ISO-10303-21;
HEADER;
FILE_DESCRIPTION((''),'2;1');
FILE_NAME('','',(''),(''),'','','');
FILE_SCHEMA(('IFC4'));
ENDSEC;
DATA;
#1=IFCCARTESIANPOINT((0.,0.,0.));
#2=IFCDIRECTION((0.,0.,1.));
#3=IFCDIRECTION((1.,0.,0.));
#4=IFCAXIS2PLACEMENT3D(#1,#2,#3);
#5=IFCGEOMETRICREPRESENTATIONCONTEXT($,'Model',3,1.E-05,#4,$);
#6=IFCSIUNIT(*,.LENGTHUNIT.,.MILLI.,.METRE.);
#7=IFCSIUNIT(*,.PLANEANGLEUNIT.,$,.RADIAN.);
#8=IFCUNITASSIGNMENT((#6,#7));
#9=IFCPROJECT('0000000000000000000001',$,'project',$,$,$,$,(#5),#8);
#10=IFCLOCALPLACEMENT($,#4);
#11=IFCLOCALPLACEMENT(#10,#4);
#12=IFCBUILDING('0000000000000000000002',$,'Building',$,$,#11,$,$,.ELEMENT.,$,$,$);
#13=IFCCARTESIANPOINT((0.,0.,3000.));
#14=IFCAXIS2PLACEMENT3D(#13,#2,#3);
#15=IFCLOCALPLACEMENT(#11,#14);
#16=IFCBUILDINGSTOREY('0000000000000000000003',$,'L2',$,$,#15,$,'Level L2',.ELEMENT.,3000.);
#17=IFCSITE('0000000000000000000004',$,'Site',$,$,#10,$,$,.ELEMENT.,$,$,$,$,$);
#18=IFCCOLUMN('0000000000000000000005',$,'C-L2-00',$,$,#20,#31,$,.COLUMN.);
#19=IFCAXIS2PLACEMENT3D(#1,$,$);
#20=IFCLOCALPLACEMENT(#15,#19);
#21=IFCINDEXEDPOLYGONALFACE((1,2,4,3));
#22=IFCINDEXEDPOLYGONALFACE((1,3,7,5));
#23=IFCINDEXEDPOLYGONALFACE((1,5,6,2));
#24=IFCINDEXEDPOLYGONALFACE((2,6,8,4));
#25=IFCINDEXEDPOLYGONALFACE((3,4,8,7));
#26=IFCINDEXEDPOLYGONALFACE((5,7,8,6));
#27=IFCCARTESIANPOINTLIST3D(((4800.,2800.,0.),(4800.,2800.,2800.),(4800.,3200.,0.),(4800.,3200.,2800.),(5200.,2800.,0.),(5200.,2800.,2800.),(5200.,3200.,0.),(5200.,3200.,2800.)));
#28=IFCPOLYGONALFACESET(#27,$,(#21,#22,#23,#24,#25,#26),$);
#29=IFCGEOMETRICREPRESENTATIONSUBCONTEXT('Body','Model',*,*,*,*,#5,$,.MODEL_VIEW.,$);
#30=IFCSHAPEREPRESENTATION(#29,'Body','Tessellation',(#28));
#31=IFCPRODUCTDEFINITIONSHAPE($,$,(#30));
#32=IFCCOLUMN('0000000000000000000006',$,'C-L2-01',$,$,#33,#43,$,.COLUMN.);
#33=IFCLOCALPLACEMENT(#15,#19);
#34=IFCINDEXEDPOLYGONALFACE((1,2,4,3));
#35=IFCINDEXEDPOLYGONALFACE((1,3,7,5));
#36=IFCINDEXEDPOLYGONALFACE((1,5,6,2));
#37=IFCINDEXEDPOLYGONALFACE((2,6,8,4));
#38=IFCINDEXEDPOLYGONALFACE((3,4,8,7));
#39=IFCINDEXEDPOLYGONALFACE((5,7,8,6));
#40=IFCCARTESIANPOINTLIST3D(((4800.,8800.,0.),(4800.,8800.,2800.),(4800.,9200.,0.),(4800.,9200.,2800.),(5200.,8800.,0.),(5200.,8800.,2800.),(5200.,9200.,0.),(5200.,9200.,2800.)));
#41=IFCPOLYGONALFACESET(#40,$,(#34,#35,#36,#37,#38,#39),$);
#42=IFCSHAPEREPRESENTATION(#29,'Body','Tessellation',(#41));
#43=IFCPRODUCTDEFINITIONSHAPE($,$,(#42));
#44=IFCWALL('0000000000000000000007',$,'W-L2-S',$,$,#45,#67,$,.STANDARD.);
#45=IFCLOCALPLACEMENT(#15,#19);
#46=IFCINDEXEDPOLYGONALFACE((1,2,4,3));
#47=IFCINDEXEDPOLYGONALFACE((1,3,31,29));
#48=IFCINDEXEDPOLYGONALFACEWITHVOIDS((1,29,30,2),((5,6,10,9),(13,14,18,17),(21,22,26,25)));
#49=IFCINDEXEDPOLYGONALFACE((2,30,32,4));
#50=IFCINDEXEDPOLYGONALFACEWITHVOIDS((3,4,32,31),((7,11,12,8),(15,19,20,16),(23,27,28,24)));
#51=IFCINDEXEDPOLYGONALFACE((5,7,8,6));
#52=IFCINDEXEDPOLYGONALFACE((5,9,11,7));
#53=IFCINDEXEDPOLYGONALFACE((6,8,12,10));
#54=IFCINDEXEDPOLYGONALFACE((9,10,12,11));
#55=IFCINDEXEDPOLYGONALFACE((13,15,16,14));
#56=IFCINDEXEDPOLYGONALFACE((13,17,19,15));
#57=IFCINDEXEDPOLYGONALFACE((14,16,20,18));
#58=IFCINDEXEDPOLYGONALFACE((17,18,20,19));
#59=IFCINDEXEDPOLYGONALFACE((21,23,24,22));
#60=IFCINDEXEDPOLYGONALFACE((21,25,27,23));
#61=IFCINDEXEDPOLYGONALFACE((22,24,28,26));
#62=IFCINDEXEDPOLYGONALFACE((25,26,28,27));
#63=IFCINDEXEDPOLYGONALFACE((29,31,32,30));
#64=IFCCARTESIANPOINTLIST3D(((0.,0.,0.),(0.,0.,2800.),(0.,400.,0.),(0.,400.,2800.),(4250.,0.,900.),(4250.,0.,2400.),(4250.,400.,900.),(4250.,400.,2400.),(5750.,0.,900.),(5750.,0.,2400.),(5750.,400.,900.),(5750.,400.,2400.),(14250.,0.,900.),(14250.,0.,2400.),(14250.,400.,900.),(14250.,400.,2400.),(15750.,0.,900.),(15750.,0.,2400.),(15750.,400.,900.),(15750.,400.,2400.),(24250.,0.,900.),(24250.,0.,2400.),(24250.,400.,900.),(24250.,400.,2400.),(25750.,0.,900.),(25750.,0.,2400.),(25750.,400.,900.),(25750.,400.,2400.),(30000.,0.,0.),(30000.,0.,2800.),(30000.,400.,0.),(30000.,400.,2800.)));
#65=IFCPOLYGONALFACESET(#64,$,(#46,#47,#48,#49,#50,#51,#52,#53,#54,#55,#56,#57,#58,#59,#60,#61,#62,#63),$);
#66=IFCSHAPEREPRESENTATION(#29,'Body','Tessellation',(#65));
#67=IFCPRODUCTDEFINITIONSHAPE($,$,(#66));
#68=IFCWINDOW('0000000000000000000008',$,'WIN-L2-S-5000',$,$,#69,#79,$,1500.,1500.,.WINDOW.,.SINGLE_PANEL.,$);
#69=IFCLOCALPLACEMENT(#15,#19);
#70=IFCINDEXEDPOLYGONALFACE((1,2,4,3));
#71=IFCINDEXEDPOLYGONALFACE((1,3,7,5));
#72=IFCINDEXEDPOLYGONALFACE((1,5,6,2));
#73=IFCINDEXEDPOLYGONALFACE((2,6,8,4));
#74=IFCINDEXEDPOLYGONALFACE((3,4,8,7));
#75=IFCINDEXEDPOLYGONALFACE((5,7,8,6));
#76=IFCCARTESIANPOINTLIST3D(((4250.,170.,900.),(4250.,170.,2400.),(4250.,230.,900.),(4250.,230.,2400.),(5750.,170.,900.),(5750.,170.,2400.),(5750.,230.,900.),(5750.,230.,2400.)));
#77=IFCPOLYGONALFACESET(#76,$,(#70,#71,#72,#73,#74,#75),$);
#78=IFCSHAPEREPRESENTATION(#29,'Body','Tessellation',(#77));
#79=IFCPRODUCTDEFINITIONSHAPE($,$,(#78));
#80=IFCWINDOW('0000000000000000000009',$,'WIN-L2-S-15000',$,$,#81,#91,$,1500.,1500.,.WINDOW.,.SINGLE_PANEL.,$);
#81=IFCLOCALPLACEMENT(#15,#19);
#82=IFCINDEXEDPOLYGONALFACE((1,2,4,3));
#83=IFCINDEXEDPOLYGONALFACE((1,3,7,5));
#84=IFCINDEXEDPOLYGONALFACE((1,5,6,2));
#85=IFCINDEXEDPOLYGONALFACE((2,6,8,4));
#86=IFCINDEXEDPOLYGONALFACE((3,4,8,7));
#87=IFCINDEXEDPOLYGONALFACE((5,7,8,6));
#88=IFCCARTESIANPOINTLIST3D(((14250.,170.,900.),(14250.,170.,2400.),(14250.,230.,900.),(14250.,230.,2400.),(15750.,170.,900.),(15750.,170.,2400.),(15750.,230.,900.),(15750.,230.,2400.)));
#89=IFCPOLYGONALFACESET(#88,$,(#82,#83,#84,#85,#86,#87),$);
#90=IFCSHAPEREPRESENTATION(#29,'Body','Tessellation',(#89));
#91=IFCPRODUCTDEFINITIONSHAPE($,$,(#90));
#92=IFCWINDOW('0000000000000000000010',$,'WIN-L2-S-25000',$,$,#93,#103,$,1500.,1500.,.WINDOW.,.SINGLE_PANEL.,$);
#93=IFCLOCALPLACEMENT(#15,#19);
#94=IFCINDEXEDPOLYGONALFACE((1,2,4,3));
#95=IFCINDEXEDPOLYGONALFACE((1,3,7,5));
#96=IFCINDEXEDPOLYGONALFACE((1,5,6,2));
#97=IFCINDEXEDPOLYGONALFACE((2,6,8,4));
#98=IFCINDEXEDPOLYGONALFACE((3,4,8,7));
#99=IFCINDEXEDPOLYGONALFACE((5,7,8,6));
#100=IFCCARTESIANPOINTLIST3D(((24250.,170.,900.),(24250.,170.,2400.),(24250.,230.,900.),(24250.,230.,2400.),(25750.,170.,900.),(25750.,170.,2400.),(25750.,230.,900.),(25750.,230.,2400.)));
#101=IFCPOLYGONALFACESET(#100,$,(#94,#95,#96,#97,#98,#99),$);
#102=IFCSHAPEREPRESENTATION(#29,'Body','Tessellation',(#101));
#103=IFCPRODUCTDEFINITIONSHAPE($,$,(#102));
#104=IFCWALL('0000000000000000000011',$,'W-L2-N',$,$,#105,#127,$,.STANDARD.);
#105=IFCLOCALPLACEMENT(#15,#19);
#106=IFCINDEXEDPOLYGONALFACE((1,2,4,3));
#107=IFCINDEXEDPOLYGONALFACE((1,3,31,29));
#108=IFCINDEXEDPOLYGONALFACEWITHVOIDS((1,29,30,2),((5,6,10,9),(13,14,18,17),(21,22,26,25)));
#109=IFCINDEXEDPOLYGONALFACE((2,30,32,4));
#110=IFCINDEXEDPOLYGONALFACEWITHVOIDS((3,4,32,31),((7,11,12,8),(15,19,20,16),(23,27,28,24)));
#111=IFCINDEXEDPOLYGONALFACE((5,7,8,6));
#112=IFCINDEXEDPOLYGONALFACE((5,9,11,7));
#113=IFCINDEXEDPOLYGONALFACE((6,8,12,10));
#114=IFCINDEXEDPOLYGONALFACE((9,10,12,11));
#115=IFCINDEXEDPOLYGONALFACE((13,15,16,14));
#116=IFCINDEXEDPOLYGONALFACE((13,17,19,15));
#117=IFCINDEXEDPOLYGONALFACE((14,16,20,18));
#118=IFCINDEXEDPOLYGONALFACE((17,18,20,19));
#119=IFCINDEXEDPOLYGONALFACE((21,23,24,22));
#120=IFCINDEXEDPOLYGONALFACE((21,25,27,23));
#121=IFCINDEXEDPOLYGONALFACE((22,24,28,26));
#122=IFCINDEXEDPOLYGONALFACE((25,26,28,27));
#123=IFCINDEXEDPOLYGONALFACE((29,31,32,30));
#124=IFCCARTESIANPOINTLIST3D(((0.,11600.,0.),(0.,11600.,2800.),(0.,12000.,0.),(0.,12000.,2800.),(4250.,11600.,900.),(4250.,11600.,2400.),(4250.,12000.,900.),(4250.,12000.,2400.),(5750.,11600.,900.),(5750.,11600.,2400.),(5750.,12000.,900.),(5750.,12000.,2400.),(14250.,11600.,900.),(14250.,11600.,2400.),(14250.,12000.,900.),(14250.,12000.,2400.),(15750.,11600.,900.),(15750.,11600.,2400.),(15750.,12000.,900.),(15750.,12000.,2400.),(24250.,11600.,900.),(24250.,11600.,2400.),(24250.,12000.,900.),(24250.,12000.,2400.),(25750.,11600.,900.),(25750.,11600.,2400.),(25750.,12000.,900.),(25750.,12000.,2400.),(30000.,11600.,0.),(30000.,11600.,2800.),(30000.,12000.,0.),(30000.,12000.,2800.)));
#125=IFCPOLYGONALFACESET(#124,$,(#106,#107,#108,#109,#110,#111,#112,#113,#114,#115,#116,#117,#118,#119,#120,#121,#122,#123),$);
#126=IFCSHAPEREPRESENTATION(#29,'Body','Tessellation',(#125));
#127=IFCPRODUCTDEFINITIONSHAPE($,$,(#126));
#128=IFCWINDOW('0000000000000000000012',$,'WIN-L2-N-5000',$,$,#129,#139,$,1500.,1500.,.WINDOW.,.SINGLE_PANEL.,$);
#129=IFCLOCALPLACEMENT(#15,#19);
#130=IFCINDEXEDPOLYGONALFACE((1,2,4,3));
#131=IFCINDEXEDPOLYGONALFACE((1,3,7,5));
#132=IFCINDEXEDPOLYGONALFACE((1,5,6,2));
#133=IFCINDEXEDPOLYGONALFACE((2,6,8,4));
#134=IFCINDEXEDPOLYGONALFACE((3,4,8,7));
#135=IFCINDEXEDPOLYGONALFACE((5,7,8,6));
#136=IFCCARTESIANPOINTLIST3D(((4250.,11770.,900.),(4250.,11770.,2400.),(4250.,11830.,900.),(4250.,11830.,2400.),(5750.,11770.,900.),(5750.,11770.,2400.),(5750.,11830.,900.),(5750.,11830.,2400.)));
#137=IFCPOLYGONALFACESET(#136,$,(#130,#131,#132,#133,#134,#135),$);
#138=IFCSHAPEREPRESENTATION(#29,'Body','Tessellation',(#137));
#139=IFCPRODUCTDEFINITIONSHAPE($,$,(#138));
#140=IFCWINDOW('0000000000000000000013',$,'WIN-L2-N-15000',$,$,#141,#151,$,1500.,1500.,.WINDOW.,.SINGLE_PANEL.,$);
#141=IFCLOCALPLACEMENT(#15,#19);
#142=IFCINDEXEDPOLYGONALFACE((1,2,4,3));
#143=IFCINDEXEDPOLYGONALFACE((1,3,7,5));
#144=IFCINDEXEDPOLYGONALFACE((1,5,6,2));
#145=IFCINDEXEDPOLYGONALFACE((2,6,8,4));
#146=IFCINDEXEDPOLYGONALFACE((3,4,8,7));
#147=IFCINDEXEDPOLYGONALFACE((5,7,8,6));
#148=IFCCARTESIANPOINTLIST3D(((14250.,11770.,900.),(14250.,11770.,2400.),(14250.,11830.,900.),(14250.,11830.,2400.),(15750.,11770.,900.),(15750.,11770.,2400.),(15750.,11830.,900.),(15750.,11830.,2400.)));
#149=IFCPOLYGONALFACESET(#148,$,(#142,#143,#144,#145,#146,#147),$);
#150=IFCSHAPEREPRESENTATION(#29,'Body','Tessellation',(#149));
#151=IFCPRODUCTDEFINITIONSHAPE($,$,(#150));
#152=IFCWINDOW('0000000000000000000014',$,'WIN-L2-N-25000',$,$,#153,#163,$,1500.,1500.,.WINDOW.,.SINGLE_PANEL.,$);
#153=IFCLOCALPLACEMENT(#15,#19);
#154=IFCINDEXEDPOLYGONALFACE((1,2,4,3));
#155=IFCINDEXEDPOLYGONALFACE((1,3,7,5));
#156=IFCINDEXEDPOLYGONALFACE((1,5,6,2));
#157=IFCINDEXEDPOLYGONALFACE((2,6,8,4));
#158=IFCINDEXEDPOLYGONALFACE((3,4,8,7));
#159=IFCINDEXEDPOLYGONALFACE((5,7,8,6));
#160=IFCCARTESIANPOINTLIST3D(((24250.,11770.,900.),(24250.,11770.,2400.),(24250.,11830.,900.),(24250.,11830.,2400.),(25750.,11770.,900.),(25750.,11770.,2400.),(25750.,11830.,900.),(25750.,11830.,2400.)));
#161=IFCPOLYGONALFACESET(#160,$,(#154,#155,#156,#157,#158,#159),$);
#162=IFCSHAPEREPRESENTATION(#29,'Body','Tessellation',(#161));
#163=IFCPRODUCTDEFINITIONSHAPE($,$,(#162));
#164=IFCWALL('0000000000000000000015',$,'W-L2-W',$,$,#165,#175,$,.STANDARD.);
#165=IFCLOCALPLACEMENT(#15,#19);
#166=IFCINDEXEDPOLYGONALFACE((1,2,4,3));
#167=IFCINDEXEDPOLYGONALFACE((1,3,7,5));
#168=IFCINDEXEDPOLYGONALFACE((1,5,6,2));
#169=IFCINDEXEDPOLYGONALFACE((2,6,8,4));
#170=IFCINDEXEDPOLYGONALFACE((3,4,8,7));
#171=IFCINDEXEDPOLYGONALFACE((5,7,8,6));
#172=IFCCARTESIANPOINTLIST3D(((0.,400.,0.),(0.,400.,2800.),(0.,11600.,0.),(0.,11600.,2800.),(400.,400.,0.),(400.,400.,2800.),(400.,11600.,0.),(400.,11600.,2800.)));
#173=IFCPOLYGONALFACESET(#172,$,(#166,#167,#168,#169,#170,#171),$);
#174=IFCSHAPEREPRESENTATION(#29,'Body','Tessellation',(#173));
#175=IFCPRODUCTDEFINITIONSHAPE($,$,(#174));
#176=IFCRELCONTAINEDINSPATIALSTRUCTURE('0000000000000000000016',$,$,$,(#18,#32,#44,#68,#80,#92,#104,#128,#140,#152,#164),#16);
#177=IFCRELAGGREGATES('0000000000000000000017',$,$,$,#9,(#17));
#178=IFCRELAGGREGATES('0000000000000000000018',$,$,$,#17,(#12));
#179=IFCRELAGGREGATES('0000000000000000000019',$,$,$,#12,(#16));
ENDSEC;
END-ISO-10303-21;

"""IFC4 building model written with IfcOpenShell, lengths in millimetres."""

from ifc_helpers import new_model, si_unit, frame, origin_with_axes, origin_2d, place, context, subcontext, project, spatial, rectangle, extrude, element, fill, save


model = new_model("IFC4")

# Units and contexts
model_context = context("Model", 3, precision=1e-05, world=origin_with_axes())
body_context = subcontext(model_context, "Body", "Model", "MODEL_VIEW")
ifc_project = project(units=[si_unit("LENGTHUNIT", "METRE", prefix="MILLI"), si_unit("PLANEANGLEUNIT", "RADIAN")], contexts=[model_context])

# Site, building, storey
site_placement = place(None, origin_with_axes())
site = spatial("IfcSite", under=ifc_project, at=site_placement, Name="Site", CompositionType="ELEMENT")
building_placement = place(site_placement, origin_with_axes())
building = spatial("IfcBuilding", under=site, at=building_placement, Name="Building", CompositionType="ELEMENT")
storey_placement = place(building_placement, frame((0.0, 0.0, 3000.0), z_axis=(0.0, 0.0, 1.0), x_axis=(1.0, 0.0, 0.0)))
storey = spatial("IfcBuildingStorey", under=building, at=storey_placement, Name="L2", LongName="Level L2", CompositionType="ELEMENT", Elevation=3000.0)

# Columns
for number, where, z_axis, x_axis, name in (
    (1, (5000.0, 3000.0, 0.0), (0.0, 0.0, 1.0), (1.0, 0.0, 0.0), "C-L2-00"),
    (2, (5000.0, 9000.0, 0.0), (0.0, 0.0, 1.0), (1.0, 0.0, 0.0), "C-L2-01"),
):
    element("IfcColumn", number, at=place(storey_placement, frame(where, z_axis=z_axis, x_axis=x_axis)), inside=storey, Name=name, PredefinedType="COLUMN", context=body_context, shape_type="SweptSolid", body=[
        extrude(rectangle(XDim=400.0, YDim=400.0, at=origin_2d()), origin_with_axes(), (0.0, 0.0, 1.0), 2800.0),
    ])

# Walls, openings, windows
wall_1_placement = place(storey_placement, frame((15000.0, 200.0, 0.0), z_axis=(0.0, 0.0, 1.0), x_axis=(1.0, 0.0, 0.0)))
wall_1 = element("IfcWall", 3, at=wall_1_placement, inside=storey, Name="W-L2-S", PredefinedType="STANDARD", context=body_context, shape_type="SweptSolid", body=[
    extrude(rectangle(XDim=30000.0, YDim=400.0, at=origin_2d()), origin_with_axes(), (0.0, 0.0, 1.0), 2800.0),
])
opening_1_placement = place(wall_1_placement, frame((-10000.0, 0.0, 900.0), z_axis=(0.0, 0.0, 1.0), x_axis=(1.0, 0.0, 0.0)))
opening_1 = element("IfcOpeningElement", 4, at=opening_1_placement, cuts=wall_1, PredefinedType="OPENING", context=body_context, shape_type="SweptSolid", body=[
    extrude(rectangle(XDim=1500.0, YDim=500.0, at=origin_2d()), origin_with_axes(), (0.0, 0.0, 1.0), 1500.0),
])
opening_2_placement = place(wall_1_placement, frame((0.0, 0.0, 900.0), z_axis=(0.0, 0.0, 1.0), x_axis=(1.0, 0.0, 0.0)))
opening_2 = element("IfcOpeningElement", 5, at=opening_2_placement, cuts=wall_1, PredefinedType="OPENING", context=body_context, shape_type="SweptSolid", body=[
    extrude(rectangle(XDim=1500.0, YDim=500.0, at=origin_2d()), origin_with_axes(), (0.0, 0.0, 1.0), 1500.0),
])
opening_3_placement = place(wall_1_placement, frame((10000.0, 0.0, 900.0), z_axis=(0.0, 0.0, 1.0), x_axis=(1.0, 0.0, 0.0)))
opening_3 = element("IfcOpeningElement", 6, at=opening_3_placement, cuts=wall_1, PredefinedType="OPENING", context=body_context, shape_type="SweptSolid", body=[
    extrude(rectangle(XDim=1500.0, YDim=500.0, at=origin_2d()), origin_with_axes(), (0.0, 0.0, 1.0), 1500.0),
])
window_1_placement = place(wall_1_placement, frame((-10000.0, 0.0, 900.0), z_axis=(0.0, 0.0, 1.0), x_axis=(1.0, 0.0, 0.0)))
window_1 = element("IfcWindow", 7, at=window_1_placement, inside=storey, Name="WIN-L2-S-5000", OverallHeight=1500.0, OverallWidth=1500.0, PartitioningType="SINGLE_PANEL", PredefinedType="WINDOW", context=body_context, shape_type="SweptSolid", body=[
    extrude(rectangle(XDim=1500.0, YDim=60.0, at=origin_2d()), origin_with_axes(), (0.0, 0.0, 1.0), 1500.0),
])
fill(opening_1, window_1)
window_2_placement = place(wall_1_placement, frame((0.0, 0.0, 900.0), z_axis=(0.0, 0.0, 1.0), x_axis=(1.0, 0.0, 0.0)))
window_2 = element("IfcWindow", 8, at=window_2_placement, inside=storey, Name="WIN-L2-S-15000", OverallHeight=1500.0, OverallWidth=1500.0, PartitioningType="SINGLE_PANEL", PredefinedType="WINDOW", context=body_context, shape_type="SweptSolid", body=[
    extrude(rectangle(XDim=1500.0, YDim=60.0, at=origin_2d()), origin_with_axes(), (0.0, 0.0, 1.0), 1500.0),
])
fill(opening_2, window_2)
window_3_placement = place(wall_1_placement, frame((10000.0, 0.0, 900.0), z_axis=(0.0, 0.0, 1.0), x_axis=(1.0, 0.0, 0.0)))
window_3 = element("IfcWindow", 9, at=window_3_placement, inside=storey, Name="WIN-L2-S-25000", OverallHeight=1500.0, OverallWidth=1500.0, PartitioningType="SINGLE_PANEL", PredefinedType="WINDOW", context=body_context, shape_type="SweptSolid", body=[
    extrude(rectangle(XDim=1500.0, YDim=60.0, at=origin_2d()), origin_with_axes(), (0.0, 0.0, 1.0), 1500.0),
])
fill(opening_3, window_3)
wall_2_placement = place(storey_placement, frame((15000.0, 11800.0, 0.0), z_axis=(0.0, 0.0, 1.0), x_axis=(1.0, 0.0, 0.0)))
wall_2 = element("IfcWall", 10, at=wall_2_placement, inside=storey, Name="W-L2-N", PredefinedType="STANDARD", context=body_context, shape_type="SweptSolid", body=[
    extrude(rectangle(XDim=30000.0, YDim=400.0, at=origin_2d()), origin_with_axes(), (0.0, 0.0, 1.0), 2800.0),
])
opening_4_placement = place(wall_2_placement, frame((-10000.0, 0.0, 900.0), z_axis=(0.0, 0.0, 1.0), x_axis=(1.0, 0.0, 0.0)))
opening_4 = element("IfcOpeningElement", 11, at=opening_4_placement, cuts=wall_2, PredefinedType="OPENING", context=body_context, shape_type="SweptSolid", body=[
    extrude(rectangle(XDim=1500.0, YDim=500.0, at=origin_2d()), origin_with_axes(), (0.0, 0.0, 1.0), 1500.0),
])
opening_5_placement = place(wall_2_placement, frame((0.0, 0.0, 900.0), z_axis=(0.0, 0.0, 1.0), x_axis=(1.0, 0.0, 0.0)))
opening_5 = element("IfcOpeningElement", 12, at=opening_5_placement, cuts=wall_2, PredefinedType="OPENING", context=body_context, shape_type="SweptSolid", body=[
    extrude(rectangle(XDim=1500.0, YDim=500.0, at=origin_2d()), origin_with_axes(), (0.0, 0.0, 1.0), 1500.0),
])
opening_6_placement = place(wall_2_placement, frame((10000.0, 0.0, 900.0), z_axis=(0.0, 0.0, 1.0), x_axis=(1.0, 0.0, 0.0)))
opening_6 = element("IfcOpeningElement", 13, at=opening_6_placement, cuts=wall_2, PredefinedType="OPENING", context=body_context, shape_type="SweptSolid", body=[
    extrude(rectangle(XDim=1500.0, YDim=500.0, at=origin_2d()), origin_with_axes(), (0.0, 0.0, 1.0), 1500.0),
])
window_4_placement = place(wall_2_placement, frame((-10000.0, 0.0, 900.0), z_axis=(0.0, 0.0, 1.0), x_axis=(1.0, 0.0, 0.0)))
window_4 = element("IfcWindow", 14, at=window_4_placement, inside=storey, Name="WIN-L2-N-5000", OverallHeight=1500.0, OverallWidth=1500.0, PartitioningType="SINGLE_PANEL", PredefinedType="WINDOW", context=body_context, shape_type="SweptSolid", body=[
    extrude(rectangle(XDim=1500.0, YDim=60.0, at=origin_2d()), origin_with_axes(), (0.0, 0.0, 1.0), 1500.0),
])
fill(opening_4, window_4)
window_5_placement = place(wall_2_placement, frame((0.0, 0.0, 900.0), z_axis=(0.0, 0.0, 1.0), x_axis=(1.0, 0.0, 0.0)))
window_5 = element("IfcWindow", 15, at=window_5_placement, inside=storey, Name="WIN-L2-N-15000", OverallHeight=1500.0, OverallWidth=1500.0, PartitioningType="SINGLE_PANEL", PredefinedType="WINDOW", context=body_context, shape_type="SweptSolid", body=[
    extrude(rectangle(XDim=1500.0, YDim=60.0, at=origin_2d()), origin_with_axes(), (0.0, 0.0, 1.0), 1500.0),
])
fill(opening_5, window_5)
window_6_placement = place(wall_2_placement, frame((10000.0, 0.0, 900.0), z_axis=(0.0, 0.0, 1.0), x_axis=(1.0, 0.0, 0.0)))
window_6 = element("IfcWindow", 16, at=window_6_placement, inside=storey, Name="WIN-L2-N-25000", OverallHeight=1500.0, OverallWidth=1500.0, PartitioningType="SINGLE_PANEL", PredefinedType="WINDOW", context=body_context, shape_type="SweptSolid", body=[
    extrude(rectangle(XDim=1500.0, YDim=60.0, at=origin_2d()), origin_with_axes(), (0.0, 0.0, 1.0), 1500.0),
])
fill(opening_6, window_6)

# Wall
wall_3_placement = place(storey_placement, frame((200.0, 6000.0, 0.0), z_axis=(0.0, 0.0, 1.0), x_axis=(1.0, 0.0, 0.0)))
element("IfcWall", 17, at=wall_3_placement, inside=storey, Name="W-L2-W", PredefinedType="STANDARD", context=body_context, shape_type="SweptSolid", body=[
    extrude(rectangle(XDim=400.0, YDim=11200.0, at=origin_2d()), origin_with_axes(), (0.0, 0.0, 1.0), 2800.0),
])

save(model, "model.ifc")
